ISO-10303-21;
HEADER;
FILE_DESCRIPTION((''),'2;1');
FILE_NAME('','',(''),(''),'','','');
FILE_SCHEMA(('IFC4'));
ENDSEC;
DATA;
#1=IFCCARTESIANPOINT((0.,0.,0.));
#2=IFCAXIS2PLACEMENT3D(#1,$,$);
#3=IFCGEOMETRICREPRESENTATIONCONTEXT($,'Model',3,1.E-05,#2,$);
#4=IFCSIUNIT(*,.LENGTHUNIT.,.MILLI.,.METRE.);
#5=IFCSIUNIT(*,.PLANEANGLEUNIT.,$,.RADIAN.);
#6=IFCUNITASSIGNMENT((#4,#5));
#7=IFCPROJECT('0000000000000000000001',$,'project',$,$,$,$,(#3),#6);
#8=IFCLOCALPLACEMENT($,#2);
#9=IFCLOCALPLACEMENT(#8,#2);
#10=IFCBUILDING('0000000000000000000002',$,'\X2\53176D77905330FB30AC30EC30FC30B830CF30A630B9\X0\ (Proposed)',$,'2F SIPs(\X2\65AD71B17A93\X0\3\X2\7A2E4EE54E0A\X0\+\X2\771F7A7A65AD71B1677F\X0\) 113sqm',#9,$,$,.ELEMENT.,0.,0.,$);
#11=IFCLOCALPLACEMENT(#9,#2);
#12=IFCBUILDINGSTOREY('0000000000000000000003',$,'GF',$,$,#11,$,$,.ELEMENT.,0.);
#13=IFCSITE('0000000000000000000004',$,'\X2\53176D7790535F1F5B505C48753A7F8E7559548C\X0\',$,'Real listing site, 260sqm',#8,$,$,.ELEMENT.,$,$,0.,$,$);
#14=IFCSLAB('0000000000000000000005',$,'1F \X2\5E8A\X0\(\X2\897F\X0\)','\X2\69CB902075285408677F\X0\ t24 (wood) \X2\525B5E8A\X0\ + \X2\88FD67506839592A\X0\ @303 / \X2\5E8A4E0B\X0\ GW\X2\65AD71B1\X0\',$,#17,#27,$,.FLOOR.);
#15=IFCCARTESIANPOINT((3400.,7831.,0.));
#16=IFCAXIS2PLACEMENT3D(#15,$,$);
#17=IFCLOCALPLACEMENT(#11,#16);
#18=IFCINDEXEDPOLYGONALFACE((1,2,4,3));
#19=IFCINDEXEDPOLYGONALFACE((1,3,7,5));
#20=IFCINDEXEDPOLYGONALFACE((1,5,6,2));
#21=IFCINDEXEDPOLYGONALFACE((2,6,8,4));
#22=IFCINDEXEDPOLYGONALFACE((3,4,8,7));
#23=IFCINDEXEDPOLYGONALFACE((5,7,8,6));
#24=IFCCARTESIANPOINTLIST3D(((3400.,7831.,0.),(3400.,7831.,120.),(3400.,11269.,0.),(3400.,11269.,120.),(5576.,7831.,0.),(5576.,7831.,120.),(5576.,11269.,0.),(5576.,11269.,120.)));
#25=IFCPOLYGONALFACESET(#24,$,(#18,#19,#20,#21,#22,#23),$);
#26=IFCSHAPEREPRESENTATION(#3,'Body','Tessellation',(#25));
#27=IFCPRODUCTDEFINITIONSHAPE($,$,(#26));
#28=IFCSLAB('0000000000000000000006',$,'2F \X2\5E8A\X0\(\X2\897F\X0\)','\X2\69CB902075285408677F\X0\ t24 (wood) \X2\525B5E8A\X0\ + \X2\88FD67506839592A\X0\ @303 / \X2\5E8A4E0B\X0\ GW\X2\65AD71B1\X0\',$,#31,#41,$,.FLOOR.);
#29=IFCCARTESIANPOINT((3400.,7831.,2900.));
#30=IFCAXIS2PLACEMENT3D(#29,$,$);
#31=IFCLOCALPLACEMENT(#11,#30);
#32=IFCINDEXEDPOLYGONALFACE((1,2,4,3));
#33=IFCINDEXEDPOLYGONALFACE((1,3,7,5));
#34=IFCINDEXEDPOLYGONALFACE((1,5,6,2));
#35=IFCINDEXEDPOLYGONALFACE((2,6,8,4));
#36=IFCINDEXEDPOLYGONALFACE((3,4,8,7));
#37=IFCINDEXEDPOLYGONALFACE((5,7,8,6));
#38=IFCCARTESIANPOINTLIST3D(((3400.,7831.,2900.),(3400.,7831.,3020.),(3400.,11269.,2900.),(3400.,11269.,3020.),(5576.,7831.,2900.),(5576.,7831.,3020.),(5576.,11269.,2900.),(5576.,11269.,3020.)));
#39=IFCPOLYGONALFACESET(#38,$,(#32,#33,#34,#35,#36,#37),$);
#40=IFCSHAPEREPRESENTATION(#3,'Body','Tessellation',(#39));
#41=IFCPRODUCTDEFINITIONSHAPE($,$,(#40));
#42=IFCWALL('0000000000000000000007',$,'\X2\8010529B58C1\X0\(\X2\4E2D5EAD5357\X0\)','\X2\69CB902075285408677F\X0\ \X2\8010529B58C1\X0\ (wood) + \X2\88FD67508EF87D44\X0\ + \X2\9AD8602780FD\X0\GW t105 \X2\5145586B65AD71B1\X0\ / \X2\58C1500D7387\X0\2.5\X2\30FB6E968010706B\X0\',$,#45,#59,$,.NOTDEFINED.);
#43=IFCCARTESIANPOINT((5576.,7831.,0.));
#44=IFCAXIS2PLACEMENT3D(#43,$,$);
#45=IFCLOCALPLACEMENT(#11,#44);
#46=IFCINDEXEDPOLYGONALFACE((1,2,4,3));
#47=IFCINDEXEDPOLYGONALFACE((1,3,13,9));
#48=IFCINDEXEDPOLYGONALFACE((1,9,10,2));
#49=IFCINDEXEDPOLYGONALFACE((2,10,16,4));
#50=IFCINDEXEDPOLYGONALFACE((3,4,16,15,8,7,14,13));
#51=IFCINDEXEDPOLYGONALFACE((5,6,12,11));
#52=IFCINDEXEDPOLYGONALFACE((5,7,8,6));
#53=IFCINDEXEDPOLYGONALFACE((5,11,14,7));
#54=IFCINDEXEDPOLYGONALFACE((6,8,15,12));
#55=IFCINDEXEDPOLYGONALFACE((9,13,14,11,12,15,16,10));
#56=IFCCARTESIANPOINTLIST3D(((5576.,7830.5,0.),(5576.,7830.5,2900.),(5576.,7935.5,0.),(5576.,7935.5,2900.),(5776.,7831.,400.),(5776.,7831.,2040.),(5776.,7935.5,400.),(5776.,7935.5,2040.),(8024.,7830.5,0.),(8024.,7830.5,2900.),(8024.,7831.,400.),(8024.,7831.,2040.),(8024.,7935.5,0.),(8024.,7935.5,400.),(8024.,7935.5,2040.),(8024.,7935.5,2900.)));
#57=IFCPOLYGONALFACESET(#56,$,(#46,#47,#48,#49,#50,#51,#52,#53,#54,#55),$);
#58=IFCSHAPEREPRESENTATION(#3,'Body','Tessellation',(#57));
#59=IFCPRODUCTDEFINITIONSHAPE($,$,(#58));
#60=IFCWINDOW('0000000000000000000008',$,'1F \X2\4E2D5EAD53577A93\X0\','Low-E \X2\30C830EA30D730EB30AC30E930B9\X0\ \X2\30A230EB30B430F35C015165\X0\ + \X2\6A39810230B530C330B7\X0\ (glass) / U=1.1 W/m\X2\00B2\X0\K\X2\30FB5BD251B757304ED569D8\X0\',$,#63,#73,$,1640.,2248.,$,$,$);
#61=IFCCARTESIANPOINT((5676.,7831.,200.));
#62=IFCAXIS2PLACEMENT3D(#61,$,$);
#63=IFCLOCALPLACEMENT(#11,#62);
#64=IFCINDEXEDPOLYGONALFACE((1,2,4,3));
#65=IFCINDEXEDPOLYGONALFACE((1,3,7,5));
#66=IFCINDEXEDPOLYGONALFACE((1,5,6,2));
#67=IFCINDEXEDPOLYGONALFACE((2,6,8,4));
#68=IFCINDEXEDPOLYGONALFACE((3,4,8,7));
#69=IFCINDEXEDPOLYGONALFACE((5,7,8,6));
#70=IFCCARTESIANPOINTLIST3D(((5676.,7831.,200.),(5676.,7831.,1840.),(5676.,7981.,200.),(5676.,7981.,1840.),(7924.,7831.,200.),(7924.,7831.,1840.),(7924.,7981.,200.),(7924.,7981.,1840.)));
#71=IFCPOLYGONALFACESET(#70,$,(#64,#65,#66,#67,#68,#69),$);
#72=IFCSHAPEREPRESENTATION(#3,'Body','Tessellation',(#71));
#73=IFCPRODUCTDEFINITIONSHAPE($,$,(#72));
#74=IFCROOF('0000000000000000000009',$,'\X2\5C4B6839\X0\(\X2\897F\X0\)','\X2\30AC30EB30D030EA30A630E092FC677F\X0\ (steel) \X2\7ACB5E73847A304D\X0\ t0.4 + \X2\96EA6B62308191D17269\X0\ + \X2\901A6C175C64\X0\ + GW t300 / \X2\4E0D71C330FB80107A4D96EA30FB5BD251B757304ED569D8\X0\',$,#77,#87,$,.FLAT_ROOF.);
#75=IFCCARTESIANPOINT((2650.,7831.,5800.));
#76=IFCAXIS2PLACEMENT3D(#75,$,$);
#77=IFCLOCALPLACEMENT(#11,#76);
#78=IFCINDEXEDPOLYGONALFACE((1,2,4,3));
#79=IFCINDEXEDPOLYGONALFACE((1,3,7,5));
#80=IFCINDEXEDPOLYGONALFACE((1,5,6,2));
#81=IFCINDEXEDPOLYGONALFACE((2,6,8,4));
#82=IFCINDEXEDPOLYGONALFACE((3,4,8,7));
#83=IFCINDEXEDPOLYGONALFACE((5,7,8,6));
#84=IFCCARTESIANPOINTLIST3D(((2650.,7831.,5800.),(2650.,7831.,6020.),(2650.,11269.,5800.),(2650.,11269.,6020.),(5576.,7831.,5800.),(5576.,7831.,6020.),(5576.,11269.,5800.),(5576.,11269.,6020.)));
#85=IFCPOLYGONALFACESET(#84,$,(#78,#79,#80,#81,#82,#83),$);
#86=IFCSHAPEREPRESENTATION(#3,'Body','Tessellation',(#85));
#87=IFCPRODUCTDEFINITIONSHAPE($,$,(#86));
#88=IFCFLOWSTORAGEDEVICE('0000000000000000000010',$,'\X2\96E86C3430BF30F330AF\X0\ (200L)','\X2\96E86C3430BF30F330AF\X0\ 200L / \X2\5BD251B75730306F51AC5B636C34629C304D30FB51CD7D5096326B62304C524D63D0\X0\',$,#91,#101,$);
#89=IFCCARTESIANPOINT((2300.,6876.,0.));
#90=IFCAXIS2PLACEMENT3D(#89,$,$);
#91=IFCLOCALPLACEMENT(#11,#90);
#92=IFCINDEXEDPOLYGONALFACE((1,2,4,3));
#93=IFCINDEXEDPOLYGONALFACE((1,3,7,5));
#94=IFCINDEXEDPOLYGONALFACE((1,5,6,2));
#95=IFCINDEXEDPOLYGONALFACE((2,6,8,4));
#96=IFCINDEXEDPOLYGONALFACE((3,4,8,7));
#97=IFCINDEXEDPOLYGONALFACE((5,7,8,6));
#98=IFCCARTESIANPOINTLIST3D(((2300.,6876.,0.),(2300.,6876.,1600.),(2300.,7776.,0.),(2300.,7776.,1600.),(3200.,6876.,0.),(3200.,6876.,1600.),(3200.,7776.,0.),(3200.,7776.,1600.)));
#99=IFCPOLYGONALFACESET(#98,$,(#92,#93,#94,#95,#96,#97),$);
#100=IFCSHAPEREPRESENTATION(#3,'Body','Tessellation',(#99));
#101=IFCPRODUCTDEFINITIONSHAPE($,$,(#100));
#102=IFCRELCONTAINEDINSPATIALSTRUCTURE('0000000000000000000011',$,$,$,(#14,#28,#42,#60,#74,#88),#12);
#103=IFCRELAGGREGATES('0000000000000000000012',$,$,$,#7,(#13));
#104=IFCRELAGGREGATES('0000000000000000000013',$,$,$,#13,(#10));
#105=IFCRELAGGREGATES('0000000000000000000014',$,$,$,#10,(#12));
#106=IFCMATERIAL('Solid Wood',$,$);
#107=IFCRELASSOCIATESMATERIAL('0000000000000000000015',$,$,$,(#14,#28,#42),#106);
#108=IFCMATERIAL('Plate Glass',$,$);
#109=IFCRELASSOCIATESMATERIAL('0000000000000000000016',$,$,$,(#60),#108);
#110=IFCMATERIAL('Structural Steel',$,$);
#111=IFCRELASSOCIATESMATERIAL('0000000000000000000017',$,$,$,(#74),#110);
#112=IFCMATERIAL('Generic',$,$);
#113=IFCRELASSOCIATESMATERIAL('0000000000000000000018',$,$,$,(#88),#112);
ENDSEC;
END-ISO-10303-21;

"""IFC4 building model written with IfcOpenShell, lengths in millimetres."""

from ifc_helpers import new_model, si_unit, frame, frame_2d, origin, place, context, project, spatial, rectangle, extrude, material, element, fill, save


model = new_model("IFC4")

# Units and contexts
model_context = context("Model", 3, precision=1e-05, world=origin())
ifc_project = project(units=[si_unit("LENGTHUNIT", "METRE", prefix="MILLI"), si_unit("PLANEANGLEUNIT", "RADIAN")], contexts=[model_context])

# Site, building, storey
site_placement = place(None, origin())
site = spatial("IfcSite", under=ifc_project, at=site_placement, Name="北海道弟子屈町美留和", ObjectType="Real listing site, 260sqm", CompositionType="ELEMENT", RefElevation=0.0)
building_placement = place(site_placement, origin())
building = spatial("IfcBuilding", under=site, at=building_placement, Name="北海道・ガレージハウス (Proposed)", ObjectType="2F SIPs(断熱窓3種以上+真空断熱板) 113sqm", CompositionType="ELEMENT", ElevationOfRefHeight=0.0, ElevationOfTerrain=0.0)
storey_placement = place(building_placement, origin())
storey = spatial("IfcBuildingStorey", under=building, at=storey_placement, Name="GF", CompositionType="ELEMENT", Elevation=0.0)

# Shared definitions
ifc_material_1 = material(Name="Solid Wood")

# Slabs
slab_1_placement = place(storey_placement, frame((3400.0, 7831.0, 0.0)))
element("IfcSlab", 1, at=slab_1_placement, inside=storey, material=ifc_material_1, Name="1F 床(西)", Description="構造用合板 t24 (wood) 剛床 + 製材根太 @303 / 床下 GW断熱", PredefinedType="FLOOR", context=model_context, shape_type="SweptSolid", body=[
    extrude(rectangle(XDim=2176.0, YDim=3438.0, at=frame_2d((1088.0, 1719.0))), frame((3400.0, 7831.0, 0.0)), (0.0, 0.0, 1.0), 120.0),
])
slab_2_placement = place(storey_placement, frame((3400.0, 7831.0, 2900.0)))
element("IfcSlab", 2, at=slab_2_placement, inside=storey, material=ifc_material_1, Name="2F 床(西)", Description="構造用合板 t24 (wood) 剛床 + 製材根太 @303 / 床下 GW断熱", PredefinedType="FLOOR", context=model_context, shape_type="SweptSolid", body=[
    extrude(rectangle(XDim=2176.0, YDim=3438.0, at=frame_2d((1088.0, 1719.0))), frame((3400.0, 7831.0, 2900.0)), (0.0, 0.0, 1.0), 120.0),
])

# Wall, opening, window
wall_1_placement = place(storey_placement, frame((5576.0, 7831.0, 0.0)))
wall_1 = element("IfcWall", 3, at=wall_1_placement, inside=storey, material=ifc_material_1, Name="耐力壁(中庭南)", Description="構造用合板 耐力壁 (wood) + 製材軸組 + 高性能GW t105 充填断熱 / 壁倍率2.5・準耐火", PredefinedType="NOTDEFINED", context=model_context, shape_type="SweptSolid", body=[
    extrude(rectangle(XDim=2448.0, YDim=105.0, at=frame_2d((1224.0, 52.0))), frame((5576.0, 7831.0, 0.0)), (0.0, 0.0, 1.0), 2900.0),
])
opening_placement = place(storey_placement, frame((5676.0, 7831.0, 200.0)))
opening = element("IfcOpeningElement", 4, at=opening_placement, cuts=wall_1, PredefinedType="NOTDEFINED", context=model_context, shape_type="SweptSolid", body=[
    extrude(rectangle(XDim=2248.0, YDim=150.0, at=frame_2d((1124.0, 75.0))), frame((5676.0, 7831.0, 200.0)), (0.0, 0.0, 1.0), 1640.0),
])
ifc_material_2 = material(Name="Plate Glass")
window_placement = place(storey_placement, frame((5676.0, 7831.0, 200.0)))
window = element("IfcWindow", 5, at=window_placement, inside=storey, material=ifc_material_2, Name="1F 中庭南窓", Description="Low-E トリプルガラス アルゴン封入 + 樹脂サッシ (glass) / U=1.1 W/m²K・寒冷地仕様", OverallHeight=1640.0, OverallWidth=2248.0, context=model_context, shape_type="SweptSolid", body=[
    extrude(rectangle(XDim=2248.0, YDim=150.0, at=frame_2d((1124.0, 75.0))), frame((5676.0, 7831.0, 200.0)), (0.0, 0.0, 1.0), 1640.0),
])
fill(opening, window)

# Roof
ifc_material_3 = material(Name="Structural Steel")
for number, where, name in (
    (6, (2650.0, 7831.0, 5800.0), "屋根(西)"),
):
    element("IfcRoof", number, at=place(storey_placement, frame(where)), inside=storey, material=ifc_material_3, Name=name, Description="ガルバリウム鋼板 (steel) 立平葺き t0.4 + 雪止め金物 + 通気層 + GW t300 / 不燃・耐積雪・寒冷地仕様", PredefinedType="FLAT_ROOF", context=model_context, shape_type="SweptSolid", body=[
        extrude(rectangle(XDim=2926.0, YDim=3438.0, at=frame_2d((1463.0, 1719.0))), frame((2650.0, 7831.0, 5800.0)), (0.0, 0.0, 1.0), 220.0),
    ])

# Flow storage device
ifc_material_4 = material(Name="Generic")
flow_storage_device_placement = place(storey_placement, frame((2300.0, 6876.0, 0.0)))
element("IfcFlowStorageDevice", 7, at=flow_storage_device_placement, inside=storey, material=ifc_material_4, Name="雨水タンク (200L)", Description="雨水タンク 200L / 寒冷地は冬季水抜き・凍結防止が前提", context=model_context, shape_type="SweptSolid", body=[
    extrude(rectangle(XDim=900.0, YDim=900.0, at=frame_2d((450.0, 450.0))), frame((2300.0, 6876.0, 0.0)), (0.0, 0.0, 1.0), 1600.0),
])

save(model, "model.ifc")
